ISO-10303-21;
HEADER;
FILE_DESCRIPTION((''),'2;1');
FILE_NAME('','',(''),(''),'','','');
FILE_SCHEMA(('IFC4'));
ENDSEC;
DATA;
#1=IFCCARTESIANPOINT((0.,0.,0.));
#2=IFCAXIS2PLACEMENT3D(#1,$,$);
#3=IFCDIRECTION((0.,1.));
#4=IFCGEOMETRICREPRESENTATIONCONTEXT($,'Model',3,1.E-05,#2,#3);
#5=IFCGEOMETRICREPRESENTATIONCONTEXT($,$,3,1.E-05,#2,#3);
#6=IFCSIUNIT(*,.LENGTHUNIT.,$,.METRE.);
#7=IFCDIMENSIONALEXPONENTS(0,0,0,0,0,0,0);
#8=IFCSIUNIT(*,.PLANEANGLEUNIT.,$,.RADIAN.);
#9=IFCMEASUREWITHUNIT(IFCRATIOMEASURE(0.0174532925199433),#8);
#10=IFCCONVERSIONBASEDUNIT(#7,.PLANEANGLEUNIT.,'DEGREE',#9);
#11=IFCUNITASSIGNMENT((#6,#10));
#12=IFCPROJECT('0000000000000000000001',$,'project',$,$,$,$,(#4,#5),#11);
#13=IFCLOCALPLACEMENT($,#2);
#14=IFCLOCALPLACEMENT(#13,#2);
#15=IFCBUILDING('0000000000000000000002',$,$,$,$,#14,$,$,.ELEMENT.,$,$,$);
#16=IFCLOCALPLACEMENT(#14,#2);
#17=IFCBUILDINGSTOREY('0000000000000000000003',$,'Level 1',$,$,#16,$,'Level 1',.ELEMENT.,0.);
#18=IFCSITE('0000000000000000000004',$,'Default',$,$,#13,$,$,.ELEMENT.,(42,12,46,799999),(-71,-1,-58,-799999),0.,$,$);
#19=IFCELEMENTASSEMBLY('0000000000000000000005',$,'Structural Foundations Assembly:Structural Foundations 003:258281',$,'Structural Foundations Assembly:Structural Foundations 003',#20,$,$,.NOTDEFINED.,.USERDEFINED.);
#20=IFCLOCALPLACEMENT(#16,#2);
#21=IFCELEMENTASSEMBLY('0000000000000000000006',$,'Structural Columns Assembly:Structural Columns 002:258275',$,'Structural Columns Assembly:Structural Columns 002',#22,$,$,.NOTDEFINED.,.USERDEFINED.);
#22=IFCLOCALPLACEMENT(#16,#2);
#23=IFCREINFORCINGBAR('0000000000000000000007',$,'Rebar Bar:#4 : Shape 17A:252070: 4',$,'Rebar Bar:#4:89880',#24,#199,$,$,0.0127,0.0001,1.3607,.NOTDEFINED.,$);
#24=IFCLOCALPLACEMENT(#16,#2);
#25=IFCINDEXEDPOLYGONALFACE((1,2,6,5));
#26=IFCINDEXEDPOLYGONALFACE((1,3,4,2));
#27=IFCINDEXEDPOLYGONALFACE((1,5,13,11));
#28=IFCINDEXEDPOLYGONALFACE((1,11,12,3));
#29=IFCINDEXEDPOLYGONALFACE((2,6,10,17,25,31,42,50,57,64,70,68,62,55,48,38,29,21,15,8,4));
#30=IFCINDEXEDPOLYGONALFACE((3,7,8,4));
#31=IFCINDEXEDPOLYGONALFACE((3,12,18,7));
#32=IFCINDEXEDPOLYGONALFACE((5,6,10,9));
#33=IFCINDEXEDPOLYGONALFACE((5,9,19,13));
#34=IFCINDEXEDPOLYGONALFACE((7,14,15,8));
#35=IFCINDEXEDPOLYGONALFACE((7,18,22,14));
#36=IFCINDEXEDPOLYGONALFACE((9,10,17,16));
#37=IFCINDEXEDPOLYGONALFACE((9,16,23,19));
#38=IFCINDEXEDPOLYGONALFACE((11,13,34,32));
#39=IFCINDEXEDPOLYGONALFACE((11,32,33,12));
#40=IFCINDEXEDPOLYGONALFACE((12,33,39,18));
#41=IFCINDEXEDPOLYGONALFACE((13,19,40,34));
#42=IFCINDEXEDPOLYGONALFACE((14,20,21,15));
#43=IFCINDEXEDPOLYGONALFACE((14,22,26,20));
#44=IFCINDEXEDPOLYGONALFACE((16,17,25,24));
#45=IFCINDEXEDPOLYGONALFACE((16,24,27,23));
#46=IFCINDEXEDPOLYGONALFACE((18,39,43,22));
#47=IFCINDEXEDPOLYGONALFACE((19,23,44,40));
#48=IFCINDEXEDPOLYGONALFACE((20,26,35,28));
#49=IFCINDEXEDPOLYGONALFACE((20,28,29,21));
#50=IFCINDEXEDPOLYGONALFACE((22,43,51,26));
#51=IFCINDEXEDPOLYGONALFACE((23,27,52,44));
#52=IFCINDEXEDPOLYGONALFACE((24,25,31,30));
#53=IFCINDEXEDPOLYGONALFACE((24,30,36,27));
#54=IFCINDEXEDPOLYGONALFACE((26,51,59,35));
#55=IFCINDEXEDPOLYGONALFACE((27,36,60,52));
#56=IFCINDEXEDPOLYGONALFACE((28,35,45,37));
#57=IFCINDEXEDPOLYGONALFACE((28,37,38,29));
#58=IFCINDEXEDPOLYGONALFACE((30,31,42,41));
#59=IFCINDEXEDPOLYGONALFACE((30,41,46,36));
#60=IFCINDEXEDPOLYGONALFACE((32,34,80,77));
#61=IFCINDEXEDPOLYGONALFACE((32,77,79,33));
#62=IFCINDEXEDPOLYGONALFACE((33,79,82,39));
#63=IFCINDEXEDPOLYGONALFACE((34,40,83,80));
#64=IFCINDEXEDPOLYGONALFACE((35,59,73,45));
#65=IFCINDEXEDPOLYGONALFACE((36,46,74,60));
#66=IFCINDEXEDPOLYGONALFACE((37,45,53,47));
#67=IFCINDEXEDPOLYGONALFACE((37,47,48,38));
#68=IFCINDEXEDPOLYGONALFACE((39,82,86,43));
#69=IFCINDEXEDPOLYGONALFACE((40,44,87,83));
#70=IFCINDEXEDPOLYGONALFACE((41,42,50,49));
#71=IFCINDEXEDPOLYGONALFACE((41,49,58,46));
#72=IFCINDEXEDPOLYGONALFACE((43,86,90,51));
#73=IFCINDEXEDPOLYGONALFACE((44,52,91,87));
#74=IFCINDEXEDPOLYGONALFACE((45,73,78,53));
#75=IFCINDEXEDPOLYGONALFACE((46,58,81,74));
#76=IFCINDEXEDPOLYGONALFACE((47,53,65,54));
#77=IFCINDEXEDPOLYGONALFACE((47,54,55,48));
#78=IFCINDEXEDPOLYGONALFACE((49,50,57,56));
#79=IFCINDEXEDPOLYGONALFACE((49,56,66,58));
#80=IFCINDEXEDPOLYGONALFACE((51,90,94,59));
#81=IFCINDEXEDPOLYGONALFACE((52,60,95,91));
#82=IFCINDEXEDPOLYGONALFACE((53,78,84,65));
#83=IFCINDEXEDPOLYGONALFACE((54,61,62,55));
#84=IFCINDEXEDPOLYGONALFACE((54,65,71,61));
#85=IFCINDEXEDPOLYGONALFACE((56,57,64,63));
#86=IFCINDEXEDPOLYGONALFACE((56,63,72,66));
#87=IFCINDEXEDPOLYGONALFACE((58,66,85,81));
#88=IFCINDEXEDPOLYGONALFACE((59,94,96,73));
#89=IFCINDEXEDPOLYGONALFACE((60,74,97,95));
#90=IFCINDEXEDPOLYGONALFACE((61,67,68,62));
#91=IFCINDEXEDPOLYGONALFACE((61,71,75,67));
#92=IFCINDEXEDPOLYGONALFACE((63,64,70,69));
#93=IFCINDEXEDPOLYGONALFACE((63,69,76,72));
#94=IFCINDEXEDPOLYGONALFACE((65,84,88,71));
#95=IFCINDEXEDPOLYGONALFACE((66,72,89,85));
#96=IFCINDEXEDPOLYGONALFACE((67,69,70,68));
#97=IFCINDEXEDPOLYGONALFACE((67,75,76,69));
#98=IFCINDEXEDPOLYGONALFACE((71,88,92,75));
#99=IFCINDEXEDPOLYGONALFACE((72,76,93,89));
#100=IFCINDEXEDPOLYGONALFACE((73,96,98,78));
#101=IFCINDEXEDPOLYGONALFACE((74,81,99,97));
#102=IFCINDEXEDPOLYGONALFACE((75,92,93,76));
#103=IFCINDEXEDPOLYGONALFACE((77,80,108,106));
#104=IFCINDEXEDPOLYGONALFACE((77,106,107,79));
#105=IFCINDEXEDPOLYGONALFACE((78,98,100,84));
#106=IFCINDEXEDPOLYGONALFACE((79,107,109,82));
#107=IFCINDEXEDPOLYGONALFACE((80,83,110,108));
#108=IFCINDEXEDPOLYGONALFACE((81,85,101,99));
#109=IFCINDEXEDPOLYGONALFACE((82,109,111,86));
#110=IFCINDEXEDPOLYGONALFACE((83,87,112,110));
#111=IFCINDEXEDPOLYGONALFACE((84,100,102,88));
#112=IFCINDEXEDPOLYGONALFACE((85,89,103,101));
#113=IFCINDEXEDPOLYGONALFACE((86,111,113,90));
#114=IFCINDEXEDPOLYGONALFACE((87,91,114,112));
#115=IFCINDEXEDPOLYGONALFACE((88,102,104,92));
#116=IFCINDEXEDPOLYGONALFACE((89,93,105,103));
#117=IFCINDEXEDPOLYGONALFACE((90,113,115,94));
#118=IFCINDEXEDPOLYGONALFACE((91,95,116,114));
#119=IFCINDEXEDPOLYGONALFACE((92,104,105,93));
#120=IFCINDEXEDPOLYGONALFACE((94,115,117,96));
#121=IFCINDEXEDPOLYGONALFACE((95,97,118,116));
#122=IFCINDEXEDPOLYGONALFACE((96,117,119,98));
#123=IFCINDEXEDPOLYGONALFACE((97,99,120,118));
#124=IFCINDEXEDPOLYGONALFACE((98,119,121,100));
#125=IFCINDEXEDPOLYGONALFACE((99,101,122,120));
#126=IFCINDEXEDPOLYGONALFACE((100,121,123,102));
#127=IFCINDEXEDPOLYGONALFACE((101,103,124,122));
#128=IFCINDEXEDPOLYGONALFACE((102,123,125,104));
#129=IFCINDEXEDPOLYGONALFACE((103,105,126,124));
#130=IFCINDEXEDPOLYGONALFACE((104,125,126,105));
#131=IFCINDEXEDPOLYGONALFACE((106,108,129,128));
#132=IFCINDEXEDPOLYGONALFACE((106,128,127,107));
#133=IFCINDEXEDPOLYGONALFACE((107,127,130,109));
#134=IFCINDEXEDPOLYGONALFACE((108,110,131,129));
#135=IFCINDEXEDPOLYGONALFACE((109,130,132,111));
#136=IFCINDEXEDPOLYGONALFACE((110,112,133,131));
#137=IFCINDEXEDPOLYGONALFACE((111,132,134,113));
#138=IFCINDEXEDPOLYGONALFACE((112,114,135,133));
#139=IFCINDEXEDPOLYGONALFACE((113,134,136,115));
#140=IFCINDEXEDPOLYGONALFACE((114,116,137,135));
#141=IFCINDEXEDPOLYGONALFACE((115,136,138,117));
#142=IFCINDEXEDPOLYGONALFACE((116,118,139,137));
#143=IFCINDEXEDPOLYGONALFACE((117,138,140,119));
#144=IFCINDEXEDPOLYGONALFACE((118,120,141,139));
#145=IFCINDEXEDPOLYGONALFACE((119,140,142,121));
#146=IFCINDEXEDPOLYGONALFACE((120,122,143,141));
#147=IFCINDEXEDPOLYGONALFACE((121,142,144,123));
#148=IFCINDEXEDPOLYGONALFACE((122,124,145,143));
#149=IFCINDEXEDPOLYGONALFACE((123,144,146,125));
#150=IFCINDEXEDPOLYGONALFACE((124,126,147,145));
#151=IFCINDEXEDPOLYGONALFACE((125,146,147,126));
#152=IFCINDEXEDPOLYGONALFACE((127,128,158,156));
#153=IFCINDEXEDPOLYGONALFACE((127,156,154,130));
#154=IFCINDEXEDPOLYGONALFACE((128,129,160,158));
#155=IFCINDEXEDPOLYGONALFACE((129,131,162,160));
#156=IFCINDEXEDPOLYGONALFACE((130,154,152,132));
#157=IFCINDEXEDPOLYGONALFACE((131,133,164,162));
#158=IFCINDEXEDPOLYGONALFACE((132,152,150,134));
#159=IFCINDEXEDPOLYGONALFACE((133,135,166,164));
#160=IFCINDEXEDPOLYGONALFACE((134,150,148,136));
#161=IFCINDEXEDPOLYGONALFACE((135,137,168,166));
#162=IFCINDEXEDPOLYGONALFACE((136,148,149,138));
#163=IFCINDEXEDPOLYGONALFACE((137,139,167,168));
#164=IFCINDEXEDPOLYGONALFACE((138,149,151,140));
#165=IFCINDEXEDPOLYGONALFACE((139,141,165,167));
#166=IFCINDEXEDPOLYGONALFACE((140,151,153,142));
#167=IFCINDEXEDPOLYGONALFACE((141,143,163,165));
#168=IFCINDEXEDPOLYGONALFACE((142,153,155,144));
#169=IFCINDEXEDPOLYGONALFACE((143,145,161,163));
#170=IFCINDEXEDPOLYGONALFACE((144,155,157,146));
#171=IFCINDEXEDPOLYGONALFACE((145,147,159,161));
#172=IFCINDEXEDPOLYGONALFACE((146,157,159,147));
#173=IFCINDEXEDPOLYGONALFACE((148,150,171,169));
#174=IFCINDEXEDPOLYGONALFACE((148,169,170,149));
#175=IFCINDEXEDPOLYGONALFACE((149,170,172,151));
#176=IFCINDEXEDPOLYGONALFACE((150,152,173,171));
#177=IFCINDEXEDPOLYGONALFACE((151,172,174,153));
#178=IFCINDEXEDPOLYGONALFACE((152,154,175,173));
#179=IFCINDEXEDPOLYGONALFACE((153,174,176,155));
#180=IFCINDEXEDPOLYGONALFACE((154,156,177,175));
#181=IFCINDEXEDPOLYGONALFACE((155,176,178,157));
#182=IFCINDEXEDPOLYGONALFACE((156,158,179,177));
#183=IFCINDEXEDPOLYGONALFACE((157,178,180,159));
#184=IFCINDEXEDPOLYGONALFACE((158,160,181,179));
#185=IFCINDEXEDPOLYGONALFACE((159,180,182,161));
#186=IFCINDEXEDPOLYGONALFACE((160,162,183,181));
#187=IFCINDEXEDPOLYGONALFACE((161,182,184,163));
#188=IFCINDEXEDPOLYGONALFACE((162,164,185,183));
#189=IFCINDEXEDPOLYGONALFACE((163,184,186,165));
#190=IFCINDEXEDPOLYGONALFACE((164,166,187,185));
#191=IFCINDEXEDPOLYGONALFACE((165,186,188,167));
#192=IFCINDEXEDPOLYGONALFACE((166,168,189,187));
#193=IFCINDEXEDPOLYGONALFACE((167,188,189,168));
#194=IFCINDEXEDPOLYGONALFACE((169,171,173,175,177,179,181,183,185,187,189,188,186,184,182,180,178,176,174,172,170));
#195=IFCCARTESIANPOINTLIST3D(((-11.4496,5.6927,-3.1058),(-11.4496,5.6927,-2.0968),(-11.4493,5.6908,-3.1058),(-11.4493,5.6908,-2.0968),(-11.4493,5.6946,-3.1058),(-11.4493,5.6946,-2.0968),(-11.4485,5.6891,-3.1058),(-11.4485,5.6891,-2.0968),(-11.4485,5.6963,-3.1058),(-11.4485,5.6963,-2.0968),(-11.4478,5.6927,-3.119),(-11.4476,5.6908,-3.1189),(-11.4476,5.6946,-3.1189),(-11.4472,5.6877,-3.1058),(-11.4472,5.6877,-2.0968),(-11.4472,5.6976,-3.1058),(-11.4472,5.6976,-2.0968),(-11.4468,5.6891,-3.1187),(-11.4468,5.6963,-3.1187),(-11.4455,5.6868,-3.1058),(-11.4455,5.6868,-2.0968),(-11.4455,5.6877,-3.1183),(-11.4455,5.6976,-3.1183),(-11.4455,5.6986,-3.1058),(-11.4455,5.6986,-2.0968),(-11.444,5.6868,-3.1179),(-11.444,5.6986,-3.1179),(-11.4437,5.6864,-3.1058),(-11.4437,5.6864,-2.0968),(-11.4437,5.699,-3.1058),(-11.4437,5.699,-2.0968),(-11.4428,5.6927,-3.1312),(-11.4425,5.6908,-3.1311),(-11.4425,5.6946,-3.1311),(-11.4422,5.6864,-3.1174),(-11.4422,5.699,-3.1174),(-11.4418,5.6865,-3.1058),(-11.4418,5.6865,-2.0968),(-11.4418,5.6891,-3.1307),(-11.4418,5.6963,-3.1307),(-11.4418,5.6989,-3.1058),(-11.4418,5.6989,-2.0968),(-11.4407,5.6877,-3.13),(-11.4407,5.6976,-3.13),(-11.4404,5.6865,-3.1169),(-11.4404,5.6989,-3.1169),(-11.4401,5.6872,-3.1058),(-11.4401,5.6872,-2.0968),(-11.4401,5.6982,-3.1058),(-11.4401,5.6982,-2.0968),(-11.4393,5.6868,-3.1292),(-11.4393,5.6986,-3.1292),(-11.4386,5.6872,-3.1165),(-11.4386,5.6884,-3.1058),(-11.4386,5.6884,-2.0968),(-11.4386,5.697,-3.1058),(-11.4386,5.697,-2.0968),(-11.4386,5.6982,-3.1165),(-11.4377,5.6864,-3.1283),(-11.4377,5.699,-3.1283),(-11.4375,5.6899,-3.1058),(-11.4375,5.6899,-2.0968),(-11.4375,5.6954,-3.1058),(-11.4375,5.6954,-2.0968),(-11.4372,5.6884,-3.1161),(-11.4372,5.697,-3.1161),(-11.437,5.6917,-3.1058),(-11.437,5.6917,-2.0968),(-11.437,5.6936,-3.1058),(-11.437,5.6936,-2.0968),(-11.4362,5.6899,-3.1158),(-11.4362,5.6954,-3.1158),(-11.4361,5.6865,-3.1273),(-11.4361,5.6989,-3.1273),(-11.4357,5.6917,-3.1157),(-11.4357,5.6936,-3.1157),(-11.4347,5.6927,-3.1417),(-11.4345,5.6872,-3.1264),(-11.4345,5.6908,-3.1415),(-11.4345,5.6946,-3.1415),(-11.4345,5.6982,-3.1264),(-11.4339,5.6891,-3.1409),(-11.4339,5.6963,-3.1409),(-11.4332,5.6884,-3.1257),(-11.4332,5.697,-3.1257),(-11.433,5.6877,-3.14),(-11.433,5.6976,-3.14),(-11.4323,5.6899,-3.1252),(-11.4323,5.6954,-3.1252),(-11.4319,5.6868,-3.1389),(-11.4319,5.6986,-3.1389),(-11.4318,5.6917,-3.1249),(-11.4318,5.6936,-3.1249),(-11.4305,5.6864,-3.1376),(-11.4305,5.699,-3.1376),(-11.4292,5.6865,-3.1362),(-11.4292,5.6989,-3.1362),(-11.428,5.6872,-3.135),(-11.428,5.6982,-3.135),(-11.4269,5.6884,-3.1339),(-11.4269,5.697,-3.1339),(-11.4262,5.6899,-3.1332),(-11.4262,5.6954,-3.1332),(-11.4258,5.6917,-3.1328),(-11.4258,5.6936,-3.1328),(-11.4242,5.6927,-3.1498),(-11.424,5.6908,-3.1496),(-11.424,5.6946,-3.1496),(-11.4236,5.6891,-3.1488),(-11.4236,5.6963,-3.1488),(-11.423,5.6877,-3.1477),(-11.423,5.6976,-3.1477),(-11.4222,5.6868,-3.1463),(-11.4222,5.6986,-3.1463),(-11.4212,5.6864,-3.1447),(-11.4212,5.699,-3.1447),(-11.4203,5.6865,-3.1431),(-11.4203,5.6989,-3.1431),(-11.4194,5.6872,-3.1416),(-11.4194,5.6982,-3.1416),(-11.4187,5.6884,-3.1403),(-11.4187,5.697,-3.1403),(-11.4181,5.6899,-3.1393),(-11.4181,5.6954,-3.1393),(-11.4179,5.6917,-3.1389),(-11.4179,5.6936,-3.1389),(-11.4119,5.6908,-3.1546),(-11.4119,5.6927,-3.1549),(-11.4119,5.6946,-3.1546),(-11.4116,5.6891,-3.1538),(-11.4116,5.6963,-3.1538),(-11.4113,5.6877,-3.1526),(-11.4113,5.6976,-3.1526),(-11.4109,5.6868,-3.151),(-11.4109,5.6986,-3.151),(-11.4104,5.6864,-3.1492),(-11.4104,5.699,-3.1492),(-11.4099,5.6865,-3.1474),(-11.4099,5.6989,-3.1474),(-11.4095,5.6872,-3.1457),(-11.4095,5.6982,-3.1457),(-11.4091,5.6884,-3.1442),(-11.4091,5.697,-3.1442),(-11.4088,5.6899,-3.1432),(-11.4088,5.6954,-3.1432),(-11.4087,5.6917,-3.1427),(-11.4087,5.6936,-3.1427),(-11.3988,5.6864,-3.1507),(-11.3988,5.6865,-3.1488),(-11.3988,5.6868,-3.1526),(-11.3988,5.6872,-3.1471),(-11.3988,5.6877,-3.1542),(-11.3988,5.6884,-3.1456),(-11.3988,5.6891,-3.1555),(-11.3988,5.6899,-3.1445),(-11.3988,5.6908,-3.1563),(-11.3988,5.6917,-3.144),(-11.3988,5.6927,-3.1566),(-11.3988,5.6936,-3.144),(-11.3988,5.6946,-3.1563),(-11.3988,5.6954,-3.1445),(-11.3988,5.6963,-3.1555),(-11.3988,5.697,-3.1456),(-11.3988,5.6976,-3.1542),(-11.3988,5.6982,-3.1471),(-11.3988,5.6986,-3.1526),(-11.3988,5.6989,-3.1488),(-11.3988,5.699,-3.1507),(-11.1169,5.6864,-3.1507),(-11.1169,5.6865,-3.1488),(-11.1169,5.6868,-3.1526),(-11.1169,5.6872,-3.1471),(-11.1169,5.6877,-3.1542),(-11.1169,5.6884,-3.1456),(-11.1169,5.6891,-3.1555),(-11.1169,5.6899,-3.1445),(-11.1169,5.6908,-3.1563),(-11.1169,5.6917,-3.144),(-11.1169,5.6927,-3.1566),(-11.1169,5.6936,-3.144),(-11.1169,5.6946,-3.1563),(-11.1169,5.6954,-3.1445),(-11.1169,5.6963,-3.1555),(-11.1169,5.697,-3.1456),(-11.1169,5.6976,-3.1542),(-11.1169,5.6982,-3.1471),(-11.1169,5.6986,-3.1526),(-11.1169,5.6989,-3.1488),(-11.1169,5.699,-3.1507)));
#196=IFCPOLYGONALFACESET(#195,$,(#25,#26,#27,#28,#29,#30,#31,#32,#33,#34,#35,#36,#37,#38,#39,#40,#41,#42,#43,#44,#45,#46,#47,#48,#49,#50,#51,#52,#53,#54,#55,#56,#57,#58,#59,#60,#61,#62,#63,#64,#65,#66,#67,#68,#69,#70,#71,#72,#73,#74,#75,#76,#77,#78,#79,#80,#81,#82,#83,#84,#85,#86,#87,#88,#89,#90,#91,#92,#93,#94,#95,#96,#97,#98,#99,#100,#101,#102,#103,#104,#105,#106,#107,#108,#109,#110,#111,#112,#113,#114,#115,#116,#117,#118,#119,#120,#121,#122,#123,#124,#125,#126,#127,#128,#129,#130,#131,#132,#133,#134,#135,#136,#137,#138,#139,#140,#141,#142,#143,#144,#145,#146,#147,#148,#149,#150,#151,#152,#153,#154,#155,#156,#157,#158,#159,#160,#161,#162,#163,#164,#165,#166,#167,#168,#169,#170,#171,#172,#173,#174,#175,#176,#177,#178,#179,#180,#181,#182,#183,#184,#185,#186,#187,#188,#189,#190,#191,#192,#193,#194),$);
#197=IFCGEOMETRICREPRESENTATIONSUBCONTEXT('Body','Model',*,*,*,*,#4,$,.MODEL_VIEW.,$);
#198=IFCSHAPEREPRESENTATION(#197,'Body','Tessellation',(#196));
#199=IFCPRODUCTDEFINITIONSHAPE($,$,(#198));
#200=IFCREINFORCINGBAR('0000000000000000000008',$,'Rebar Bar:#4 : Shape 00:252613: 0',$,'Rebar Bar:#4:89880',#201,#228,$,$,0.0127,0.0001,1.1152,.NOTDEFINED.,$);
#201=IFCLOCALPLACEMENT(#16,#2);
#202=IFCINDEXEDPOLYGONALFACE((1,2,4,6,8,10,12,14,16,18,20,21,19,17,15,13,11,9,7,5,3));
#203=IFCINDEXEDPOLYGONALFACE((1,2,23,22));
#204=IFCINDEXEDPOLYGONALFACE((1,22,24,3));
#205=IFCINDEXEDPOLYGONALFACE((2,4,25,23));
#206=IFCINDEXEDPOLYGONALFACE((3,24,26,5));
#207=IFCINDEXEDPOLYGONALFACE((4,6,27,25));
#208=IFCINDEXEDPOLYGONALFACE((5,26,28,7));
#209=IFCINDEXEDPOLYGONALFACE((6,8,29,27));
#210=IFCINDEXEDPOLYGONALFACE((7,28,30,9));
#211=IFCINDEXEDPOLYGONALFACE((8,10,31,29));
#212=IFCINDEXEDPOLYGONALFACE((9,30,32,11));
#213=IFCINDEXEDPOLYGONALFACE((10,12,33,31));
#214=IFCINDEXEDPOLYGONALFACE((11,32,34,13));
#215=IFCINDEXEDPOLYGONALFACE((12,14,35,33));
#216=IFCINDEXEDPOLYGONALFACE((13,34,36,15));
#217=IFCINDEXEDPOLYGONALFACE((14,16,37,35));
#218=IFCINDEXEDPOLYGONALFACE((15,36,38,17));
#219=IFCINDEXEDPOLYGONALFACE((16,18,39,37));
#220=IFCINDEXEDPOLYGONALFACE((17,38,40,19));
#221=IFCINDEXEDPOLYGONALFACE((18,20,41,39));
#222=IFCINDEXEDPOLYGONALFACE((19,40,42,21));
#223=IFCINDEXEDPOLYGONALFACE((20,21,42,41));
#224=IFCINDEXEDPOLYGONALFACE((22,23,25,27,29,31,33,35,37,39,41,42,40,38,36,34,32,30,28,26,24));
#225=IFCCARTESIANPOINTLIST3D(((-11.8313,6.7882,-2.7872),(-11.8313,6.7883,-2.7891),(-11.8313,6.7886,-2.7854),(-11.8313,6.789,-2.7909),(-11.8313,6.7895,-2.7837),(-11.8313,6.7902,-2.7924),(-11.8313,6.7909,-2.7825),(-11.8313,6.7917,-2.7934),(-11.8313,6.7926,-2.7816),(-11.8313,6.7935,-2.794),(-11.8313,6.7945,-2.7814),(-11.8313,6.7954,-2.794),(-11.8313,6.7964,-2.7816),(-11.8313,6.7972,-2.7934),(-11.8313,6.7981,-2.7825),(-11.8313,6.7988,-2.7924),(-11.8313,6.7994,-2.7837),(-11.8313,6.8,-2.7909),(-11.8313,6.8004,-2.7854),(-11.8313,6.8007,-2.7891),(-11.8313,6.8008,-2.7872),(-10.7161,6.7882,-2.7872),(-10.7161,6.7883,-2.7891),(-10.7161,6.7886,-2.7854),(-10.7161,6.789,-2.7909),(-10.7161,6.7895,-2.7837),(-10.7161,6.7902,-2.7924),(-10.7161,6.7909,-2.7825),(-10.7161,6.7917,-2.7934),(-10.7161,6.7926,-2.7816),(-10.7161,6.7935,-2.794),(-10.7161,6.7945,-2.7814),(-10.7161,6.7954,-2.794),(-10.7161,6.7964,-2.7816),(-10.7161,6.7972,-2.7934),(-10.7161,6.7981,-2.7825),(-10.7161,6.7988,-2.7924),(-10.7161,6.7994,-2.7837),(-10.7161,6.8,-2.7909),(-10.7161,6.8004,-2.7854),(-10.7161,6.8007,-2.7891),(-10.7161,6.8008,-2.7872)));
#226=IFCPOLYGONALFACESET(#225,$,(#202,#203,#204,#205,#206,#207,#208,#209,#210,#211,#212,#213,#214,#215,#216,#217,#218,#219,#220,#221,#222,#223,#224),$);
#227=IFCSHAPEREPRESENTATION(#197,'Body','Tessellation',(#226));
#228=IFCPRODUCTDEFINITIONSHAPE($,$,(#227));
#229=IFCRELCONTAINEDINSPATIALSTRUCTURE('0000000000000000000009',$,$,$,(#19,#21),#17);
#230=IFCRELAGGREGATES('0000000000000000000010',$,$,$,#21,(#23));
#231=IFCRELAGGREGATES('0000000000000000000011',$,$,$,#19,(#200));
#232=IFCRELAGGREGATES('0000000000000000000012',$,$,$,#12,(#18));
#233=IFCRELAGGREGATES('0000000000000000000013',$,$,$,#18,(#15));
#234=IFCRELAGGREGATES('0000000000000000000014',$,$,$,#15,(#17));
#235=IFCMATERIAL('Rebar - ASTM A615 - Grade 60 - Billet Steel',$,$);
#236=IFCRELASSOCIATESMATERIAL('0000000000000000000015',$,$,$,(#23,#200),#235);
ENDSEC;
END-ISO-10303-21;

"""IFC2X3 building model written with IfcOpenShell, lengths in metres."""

from ifc_helpers import new_model, entity, si_unit, converted_unit, direction, origin, place, context, subcontext, project, spatial, material, element, aggregate, save


model = new_model("IFC2X3")

# Units and contexts
model_context = context("Model", 3, precision=1e-05, world=origin(), true_north=direction((0.0, 1.0)))
context_of_model = context(None, 3, precision=1e-05, world=origin(), true_north=direction((0.0, 1.0)))
body_context = subcontext(model_context, "Body", "Model", "MODEL_VIEW")
ifc_project = project(units=[si_unit("LENGTHUNIT", "METRE"), converted_unit("PLANEANGLEUNIT", "DEGREE", entity("IfcRatioMeasure", 0.0174532925199433), si_unit("PLANEANGLEUNIT", "RADIAN"), dimensions=[0, 0, 0, 0, 0, 0, 0])], contexts=[model_context, context_of_model])

# Site, building, storey
site_placement = place(None, origin())
site = spatial("IfcSite", under=ifc_project, at=site_placement, Name="Default", CompositionType="ELEMENT", RefLatitude=(42, 12, 46, 799999), RefLongitude=(-71, -1, -58, -799999), RefElevation=0.0)
building_placement = place(site_placement, origin())
building = spatial("IfcBuilding", under=site, at=building_placement, CompositionType="ELEMENT")
storey_placement = place(building_placement, origin())
storey = spatial("IfcBuildingStorey", under=building, at=storey_placement, Name="Level 1", LongName="Level 1", CompositionType="ELEMENT", Elevation=0.0)

# Element assembly
assembly_1_placement = place(storey_placement, origin())
assembly_1 = element("IfcElementAssembly", 1, at=assembly_1_placement, inside=storey, Name="Structural Foundations Assembly:Structural Foundations 003:258281", ObjectType="Structural Foundations Assembly:Structural Foundations 003", AssemblyPlace="NOTDEFINED", PredefinedType="USERDEFINED")

# Element assembly, reinforcing bar
assembly_2_placement = place(storey_placement, origin())
assembly_2 = element("IfcElementAssembly", 2, at=assembly_2_placement, inside=storey, Name="Structural Columns Assembly:Structural Columns 002:258275", ObjectType="Structural Columns Assembly:Structural Columns 002", AssemblyPlace="NOTDEFINED", PredefinedType="USERDEFINED")
ifc_material_1 = material(Name="Rebar - ASTM A615 - Grade 60 - Billet Steel")
reinforcing_bar_1_placement = place(assembly_2_placement, origin())
reinforcing_bar_1 = element("IfcReinforcingBar", 3, at=reinforcing_bar_1_placement, material=ifc_material_1, Name="Rebar Bar:#4 : Shape 17A:252070: 4", ObjectType="Rebar Bar:#4:89880", BarLength=1.3607, BarRole="NOTDEFINED", CrossSectionArea=0.0001, NominalDiameter=0.0127, context=body_context, shape_type="AdvancedSweptSolid", body=[
    entity("IfcSweptDiskSolid", entity("IfcCompositeCurve", [entity("IfcCompositeCurveSegment", "CONTINUOUS", True, entity("IfcPolyline", [entity("IfcCartesianPoint", [-11.4432, 5.6927, -2.0968]), entity("IfcCartesianPoint", [-11.4432, 5.6927, -3.1058])])), entity("IfcCompositeCurveSegment", "CONTINUOUS", True, entity("IfcTrimmedCurve", entity("IfcCircle", entity("IfcAxis2Placement3D", entity("IfcCartesianPoint", [-11.3988, 5.6927, -3.1058]), entity("IfcDirection", [0.0, -1.0, 0.0]), entity("IfcDirection", [0.0, 0.0, -1.0])), 0.0445), [entity("IfcParameterValue", 270.0)], [entity("IfcParameterValue", 360.0)], True, "PARAMETER")), entity("IfcCompositeCurveSegment", "CONTINUOUS", True, entity("IfcPolyline", [entity("IfcCartesianPoint", [-11.3988, 5.6927, -3.1503]), entity("IfcCartesianPoint", [-11.1169, 5.6927, -3.1503])]))], False), 0.0063, None, 0.0, 92.0),
])
aggregate(assembly_2, [reinforcing_bar_1])

# Reinforcing bar
reinforcing_bar_2_placement = place(assembly_1_placement, origin())
reinforcing_bar_2 = element("IfcReinforcingBar", 4, at=reinforcing_bar_2_placement, material=ifc_material_1, Name="Rebar Bar:#4 : Shape 00:252613: 0", ObjectType="Rebar Bar:#4:89880", BarLength=1.1152, BarRole="NOTDEFINED", CrossSectionArea=0.0001, NominalDiameter=0.0127, context=body_context, shape_type="AdvancedSweptSolid", body=[
    entity("IfcSweptDiskSolid", entity("IfcCompositeCurve", [entity("IfcCompositeCurveSegment", "CONTINUOUS", True, entity("IfcPolyline", [entity("IfcCartesianPoint", [-11.8313, 6.7945, -2.7877]), entity("IfcCartesianPoint", [-10.7161, 6.7945, -2.7877])]))], False), 0.0063, None, 0.0, 1.0),
])
aggregate(assembly_1, [reinforcing_bar_2])

save(model, "model.ifc")
